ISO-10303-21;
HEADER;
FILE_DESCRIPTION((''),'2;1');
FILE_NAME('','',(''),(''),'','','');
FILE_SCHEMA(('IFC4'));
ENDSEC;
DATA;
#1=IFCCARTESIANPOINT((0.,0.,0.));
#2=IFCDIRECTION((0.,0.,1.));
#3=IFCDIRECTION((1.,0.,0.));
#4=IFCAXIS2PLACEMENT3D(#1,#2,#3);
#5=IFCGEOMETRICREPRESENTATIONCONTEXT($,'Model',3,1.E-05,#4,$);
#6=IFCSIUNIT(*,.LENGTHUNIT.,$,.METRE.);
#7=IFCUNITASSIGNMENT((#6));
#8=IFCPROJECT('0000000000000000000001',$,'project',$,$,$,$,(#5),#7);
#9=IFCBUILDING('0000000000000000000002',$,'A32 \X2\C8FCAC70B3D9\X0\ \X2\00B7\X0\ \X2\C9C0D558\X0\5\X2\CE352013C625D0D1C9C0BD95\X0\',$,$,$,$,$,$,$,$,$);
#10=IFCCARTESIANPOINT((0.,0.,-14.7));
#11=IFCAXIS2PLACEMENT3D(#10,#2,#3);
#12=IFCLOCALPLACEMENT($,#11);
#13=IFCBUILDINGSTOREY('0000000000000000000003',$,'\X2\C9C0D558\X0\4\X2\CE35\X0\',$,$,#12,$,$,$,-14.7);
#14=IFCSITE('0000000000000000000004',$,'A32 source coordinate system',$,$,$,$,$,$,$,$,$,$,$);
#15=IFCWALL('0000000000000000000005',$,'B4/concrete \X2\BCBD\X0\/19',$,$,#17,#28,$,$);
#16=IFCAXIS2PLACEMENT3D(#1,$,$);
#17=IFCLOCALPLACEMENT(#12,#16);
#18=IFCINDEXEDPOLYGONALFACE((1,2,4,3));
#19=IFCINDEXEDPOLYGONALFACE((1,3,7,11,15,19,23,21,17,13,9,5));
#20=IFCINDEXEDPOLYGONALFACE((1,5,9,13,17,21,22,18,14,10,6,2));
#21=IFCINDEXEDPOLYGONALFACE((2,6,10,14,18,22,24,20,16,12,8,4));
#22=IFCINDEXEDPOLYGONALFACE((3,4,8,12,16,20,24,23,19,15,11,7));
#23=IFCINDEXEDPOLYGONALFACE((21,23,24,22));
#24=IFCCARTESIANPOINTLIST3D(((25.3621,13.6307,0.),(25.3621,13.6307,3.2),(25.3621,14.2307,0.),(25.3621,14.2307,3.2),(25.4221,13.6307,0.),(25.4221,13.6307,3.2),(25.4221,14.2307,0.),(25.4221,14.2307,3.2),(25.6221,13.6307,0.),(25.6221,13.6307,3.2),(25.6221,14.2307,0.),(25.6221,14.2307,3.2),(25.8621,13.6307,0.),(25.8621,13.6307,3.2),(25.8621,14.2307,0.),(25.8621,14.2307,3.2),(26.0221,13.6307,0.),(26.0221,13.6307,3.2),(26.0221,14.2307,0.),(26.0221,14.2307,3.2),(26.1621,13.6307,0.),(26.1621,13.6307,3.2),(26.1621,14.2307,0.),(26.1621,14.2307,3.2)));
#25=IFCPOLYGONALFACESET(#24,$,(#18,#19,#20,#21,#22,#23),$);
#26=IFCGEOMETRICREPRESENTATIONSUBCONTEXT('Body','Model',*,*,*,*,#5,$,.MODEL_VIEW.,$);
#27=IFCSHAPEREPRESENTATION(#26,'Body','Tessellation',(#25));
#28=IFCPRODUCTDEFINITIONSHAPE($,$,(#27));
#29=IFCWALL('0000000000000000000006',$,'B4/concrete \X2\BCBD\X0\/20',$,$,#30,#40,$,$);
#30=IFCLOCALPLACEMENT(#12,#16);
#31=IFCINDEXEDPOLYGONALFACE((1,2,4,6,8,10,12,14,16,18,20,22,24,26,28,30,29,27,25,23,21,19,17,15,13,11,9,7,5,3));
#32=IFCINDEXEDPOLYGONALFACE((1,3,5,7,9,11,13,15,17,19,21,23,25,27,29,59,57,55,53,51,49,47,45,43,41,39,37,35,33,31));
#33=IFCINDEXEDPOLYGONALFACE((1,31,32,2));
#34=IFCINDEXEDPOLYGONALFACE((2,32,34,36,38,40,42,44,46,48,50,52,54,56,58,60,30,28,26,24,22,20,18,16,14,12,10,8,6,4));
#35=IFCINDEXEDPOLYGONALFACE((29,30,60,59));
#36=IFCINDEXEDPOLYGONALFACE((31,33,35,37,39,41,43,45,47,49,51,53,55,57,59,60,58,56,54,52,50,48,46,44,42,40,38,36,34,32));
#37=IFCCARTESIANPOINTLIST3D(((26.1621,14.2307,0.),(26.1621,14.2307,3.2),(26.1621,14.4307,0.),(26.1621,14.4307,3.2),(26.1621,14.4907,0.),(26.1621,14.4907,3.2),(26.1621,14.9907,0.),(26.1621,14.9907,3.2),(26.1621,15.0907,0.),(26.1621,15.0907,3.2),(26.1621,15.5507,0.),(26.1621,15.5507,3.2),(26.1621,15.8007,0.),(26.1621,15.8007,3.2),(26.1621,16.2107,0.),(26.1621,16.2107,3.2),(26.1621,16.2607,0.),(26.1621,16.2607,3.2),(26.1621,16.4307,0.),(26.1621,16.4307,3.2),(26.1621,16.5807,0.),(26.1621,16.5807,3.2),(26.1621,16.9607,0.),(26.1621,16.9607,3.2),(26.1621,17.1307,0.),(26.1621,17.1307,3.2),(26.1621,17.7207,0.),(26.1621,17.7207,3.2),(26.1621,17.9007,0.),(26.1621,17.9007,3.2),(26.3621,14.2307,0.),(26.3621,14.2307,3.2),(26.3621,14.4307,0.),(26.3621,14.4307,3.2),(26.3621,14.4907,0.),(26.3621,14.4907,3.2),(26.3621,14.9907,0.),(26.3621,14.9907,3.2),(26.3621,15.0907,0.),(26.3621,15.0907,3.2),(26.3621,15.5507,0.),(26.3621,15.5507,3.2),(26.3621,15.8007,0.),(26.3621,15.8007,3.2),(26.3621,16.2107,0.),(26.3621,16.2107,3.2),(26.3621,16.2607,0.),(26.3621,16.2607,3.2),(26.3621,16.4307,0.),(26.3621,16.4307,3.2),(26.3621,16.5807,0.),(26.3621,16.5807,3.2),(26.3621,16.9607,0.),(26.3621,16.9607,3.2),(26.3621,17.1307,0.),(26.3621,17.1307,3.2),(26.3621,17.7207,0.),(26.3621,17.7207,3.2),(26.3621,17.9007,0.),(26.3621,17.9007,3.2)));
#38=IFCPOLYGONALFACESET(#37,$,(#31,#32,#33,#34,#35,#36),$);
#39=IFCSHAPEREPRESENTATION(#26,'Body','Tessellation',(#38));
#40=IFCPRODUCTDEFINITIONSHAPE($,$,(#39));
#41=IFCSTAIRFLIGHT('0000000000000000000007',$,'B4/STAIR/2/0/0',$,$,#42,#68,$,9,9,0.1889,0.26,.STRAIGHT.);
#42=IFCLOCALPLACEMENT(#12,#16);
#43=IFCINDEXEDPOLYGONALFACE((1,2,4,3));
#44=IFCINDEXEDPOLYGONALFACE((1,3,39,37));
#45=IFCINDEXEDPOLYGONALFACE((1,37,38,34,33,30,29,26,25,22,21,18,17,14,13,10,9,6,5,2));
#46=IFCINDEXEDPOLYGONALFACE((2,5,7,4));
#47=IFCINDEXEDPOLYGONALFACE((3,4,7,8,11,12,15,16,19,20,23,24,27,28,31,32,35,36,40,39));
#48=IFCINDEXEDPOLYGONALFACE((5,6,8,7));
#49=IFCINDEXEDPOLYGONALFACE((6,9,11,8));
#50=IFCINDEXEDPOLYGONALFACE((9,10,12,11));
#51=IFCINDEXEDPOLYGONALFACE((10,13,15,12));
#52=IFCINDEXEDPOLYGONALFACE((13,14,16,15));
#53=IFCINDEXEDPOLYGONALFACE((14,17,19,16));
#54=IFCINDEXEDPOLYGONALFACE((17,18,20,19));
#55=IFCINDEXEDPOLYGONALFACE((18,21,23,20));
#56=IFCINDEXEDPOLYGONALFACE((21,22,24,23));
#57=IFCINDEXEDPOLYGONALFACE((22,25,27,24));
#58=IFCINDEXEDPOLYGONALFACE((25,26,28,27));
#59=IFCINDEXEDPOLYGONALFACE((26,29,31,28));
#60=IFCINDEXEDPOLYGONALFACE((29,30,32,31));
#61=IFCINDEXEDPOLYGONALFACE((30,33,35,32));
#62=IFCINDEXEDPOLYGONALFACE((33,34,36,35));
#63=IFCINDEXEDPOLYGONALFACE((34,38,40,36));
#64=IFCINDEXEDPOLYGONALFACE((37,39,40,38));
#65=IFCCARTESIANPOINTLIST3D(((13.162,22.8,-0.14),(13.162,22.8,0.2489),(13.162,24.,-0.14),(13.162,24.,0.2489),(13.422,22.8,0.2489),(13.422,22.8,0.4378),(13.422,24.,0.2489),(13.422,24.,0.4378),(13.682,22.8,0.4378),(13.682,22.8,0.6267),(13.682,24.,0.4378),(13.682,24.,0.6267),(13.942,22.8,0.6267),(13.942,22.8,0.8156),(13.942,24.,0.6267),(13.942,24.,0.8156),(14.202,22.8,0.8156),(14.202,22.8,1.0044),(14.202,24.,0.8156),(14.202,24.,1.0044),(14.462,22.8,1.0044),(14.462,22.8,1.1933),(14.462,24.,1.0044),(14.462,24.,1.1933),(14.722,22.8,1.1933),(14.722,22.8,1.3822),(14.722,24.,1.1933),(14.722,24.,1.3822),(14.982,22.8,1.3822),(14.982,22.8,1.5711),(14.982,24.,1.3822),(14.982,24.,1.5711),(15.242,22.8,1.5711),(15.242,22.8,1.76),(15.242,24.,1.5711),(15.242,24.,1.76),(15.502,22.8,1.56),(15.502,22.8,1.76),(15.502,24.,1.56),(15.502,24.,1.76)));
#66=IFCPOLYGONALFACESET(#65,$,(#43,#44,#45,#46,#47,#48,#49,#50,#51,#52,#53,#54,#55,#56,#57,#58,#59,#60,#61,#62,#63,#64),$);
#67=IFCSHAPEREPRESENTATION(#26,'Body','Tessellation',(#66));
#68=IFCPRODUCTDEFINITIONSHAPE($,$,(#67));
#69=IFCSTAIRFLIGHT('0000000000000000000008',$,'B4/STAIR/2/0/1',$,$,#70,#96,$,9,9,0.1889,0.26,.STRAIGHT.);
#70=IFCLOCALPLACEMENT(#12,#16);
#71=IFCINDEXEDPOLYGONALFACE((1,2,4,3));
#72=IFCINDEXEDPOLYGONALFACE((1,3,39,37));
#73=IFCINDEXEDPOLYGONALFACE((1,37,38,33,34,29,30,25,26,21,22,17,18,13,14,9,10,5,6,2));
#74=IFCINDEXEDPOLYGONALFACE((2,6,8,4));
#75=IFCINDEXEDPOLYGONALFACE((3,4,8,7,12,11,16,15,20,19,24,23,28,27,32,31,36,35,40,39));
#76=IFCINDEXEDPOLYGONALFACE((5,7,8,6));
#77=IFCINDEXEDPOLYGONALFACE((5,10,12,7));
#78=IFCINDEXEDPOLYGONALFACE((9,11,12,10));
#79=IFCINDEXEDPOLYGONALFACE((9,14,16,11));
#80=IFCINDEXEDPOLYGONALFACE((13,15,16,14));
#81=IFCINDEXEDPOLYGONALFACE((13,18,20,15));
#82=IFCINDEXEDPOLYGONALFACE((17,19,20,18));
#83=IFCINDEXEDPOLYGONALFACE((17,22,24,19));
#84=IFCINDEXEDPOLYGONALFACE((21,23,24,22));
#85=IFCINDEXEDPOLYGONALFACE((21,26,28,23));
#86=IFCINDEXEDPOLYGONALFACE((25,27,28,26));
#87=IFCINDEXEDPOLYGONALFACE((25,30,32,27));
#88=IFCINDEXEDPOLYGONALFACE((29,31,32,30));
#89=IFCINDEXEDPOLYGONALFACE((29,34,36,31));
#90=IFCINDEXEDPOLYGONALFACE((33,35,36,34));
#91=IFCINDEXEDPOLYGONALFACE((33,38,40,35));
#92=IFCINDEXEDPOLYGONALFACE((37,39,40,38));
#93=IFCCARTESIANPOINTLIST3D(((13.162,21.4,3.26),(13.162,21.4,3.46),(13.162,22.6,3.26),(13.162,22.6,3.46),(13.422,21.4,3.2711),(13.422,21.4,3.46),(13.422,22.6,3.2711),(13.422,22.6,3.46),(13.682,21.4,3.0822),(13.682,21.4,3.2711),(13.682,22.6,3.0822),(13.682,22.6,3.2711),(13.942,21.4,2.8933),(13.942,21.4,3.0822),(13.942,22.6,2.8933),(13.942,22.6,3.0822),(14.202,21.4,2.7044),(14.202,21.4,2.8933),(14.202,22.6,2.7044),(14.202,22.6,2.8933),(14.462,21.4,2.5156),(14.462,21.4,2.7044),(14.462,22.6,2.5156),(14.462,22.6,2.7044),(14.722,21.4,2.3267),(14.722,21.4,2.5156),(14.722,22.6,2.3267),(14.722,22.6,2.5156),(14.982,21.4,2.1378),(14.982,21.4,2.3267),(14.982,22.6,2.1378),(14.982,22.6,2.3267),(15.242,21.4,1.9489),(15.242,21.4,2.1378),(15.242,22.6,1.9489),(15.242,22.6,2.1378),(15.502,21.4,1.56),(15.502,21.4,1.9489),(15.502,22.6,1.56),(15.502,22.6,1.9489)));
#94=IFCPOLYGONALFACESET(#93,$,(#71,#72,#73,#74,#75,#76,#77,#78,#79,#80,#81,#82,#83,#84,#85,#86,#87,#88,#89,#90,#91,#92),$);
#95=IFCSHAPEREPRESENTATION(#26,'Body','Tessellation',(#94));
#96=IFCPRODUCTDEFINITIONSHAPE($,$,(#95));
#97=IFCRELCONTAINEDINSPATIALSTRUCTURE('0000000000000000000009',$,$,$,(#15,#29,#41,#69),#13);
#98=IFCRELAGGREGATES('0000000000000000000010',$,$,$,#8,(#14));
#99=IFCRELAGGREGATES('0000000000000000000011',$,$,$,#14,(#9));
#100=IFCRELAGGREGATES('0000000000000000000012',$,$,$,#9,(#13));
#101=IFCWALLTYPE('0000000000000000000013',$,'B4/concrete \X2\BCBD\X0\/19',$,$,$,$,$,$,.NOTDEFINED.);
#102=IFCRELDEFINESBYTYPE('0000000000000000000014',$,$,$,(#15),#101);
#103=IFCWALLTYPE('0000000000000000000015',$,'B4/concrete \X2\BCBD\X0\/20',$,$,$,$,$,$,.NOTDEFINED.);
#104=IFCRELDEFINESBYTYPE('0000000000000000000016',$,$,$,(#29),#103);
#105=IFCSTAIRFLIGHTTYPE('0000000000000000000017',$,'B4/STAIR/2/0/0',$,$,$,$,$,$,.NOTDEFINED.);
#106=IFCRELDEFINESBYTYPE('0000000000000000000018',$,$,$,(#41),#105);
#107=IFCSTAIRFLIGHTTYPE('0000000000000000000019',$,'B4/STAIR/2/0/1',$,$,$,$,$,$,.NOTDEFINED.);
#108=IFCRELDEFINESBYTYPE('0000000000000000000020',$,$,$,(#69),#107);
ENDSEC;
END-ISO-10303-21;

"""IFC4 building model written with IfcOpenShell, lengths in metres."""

from ifc_helpers import new_model, si_unit, frame, origin, origin_with_axes, place, context, subcontext, project, spatial, polyline, outline, extrude, source, transform, mapped, type_object, type_shapes, element, save


model = new_model("IFC4")

# Units and contexts
model_context = context("Model", 3, precision=1e-05, world=origin_with_axes())
body_context = subcontext(model_context, "Body", "Model", "MODEL_VIEW")
ifc_project = project(units=[si_unit("LENGTHUNIT", "METRE")], contexts=[model_context])

# Site, building, storey
site = spatial("IfcSite", under=ifc_project, Name="A32 source coordinate system")
building = spatial("IfcBuilding", under=site, Name="A32 주거동 · 지하5층–옥탑지붕")
storey_placement = place(None, frame((0.0, 0.0, -14.7), z_axis=(0.0, 0.0, 1.0), x_axis=(1.0, 0.0, 0.0)))
storey = spatial("IfcBuildingStorey", under=building, at=storey_placement, Name="지하4층", Elevation=-14.7)

# Walls
wall_type_1 = type_object("IfcWallType", Name="B4/concrete 벽/19", PredefinedType="NOTDEFINED")
shared_shape_1 = source(origin(), body_context, "Body", "SweptSolid", [
    extrude(outline(polyline([(25.8621, 14.2307), (26.0221, 14.2307), (26.1621, 14.2307), (26.1621, 13.6307), (26.0221, 13.6307), (25.8621, 13.6307), (25.6221, 13.6307), (25.4221, 13.6307), (25.3621, 13.6307), (25.3621, 14.2307), (25.4221, 14.2307), (25.6221, 14.2307), (25.8621, 14.2307)])), origin(), (0.0, 0.0, 1.0), 3.2),
])
type_shapes(wall_type_1, [shared_shape_1])
wall_1_placement = place(storey_placement, origin_with_axes())
element("IfcWall", 1, at=wall_1_placement, inside=storey, type_object=wall_type_1, Name="B4/concrete 벽/19", context=body_context, shape_type="MappedRepresentation", body=[
    mapped(shared_shape_1, transform((0.0, 0.0, 0.0), scale=1.0)),
])
wall_type_2 = type_object("IfcWallType", Name="B4/concrete 벽/20", PredefinedType="NOTDEFINED")
shared_shape_2 = source(origin(), body_context, "Body", "SweptSolid", [
    extrude(outline(polyline([(26.1621, 14.9907), (26.1621, 15.0907), (26.1621, 15.5507), (26.1621, 15.8007), (26.1621, 16.2107), (26.1621, 16.2607), (26.1621, 16.4307), (26.1621, 16.5807), (26.1621, 16.9607), (26.1621, 17.1307), (26.1621, 17.7207), (26.1621, 17.9007), (26.3621, 17.9007), (26.3621, 17.7207), (26.3621, 17.1307), (26.3621, 16.9607), (26.3621, 16.5807), (26.3621, 16.4307), (26.3621, 16.2607), (26.3621, 16.2107), (26.3621, 15.8007), (26.3621, 15.5507), (26.3621, 15.0907), (26.3621, 14.9907), (26.3621, 14.4907), (26.3621, 14.4307), (26.3621, 14.2307), (26.1621, 14.2307), (26.1621, 14.4307), (26.1621, 14.4907), (26.1621, 14.9907)])), origin(), (0.0, 0.0, 1.0), 3.2),
])
type_shapes(wall_type_2, [shared_shape_2])
wall_2_placement = place(storey_placement, origin_with_axes())
element("IfcWall", 2, at=wall_2_placement, inside=storey, type_object=wall_type_2, Name="B4/concrete 벽/20", context=body_context, shape_type="MappedRepresentation", body=[
    mapped(shared_shape_2, transform((0.0, 0.0, 0.0), scale=1.0)),
])

# Stair flights
stair_flight_type_1 = type_object("IfcStairFlightType", Name="B4/STAIR/2/0/0", PredefinedType="NOTDEFINED")
shared_shape_3 = source(origin(), body_context, "Body", "SweptSolid", [
    extrude(outline(polyline([(0.0, -0.14), (2.34, 1.56), (2.34, 1.76), (2.08, 1.76), (2.08, 1.5711), (1.82, 1.5711), (1.82, 1.3822), (1.56, 1.3822), (1.56, 1.1933), (1.3, 1.1933), (1.3, 1.0044), (1.04, 1.0044), (1.04, 0.8156), (0.78, 0.8156), (0.78, 0.6267), (0.52, 0.6267), (0.52, 0.4378), (0.26, 0.4378), (0.26, 0.2489), (0.0, 0.2489), (0.0, -0.14)])), frame((13.162, 24.0, 0.0), z_axis=(0.0, -1.0, 0.0), x_axis=(1.0, 0.0, 0.0)), (0.0, 0.0, 1.0), 1.2),
])
type_shapes(stair_flight_type_1, [shared_shape_3])
stair_flight_1_placement = place(storey_placement, origin_with_axes())
element("IfcStairFlight", 3, at=stair_flight_1_placement, inside=storey, type_object=stair_flight_type_1, Name="B4/STAIR/2/0/0", NumberOfRisers=9, NumberOfTreads=9, PredefinedType="STRAIGHT", RiserHeight=0.1889, TreadLength=0.26, context=body_context, shape_type="MappedRepresentation", body=[
    mapped(shared_shape_3, transform((0.0, 0.0, 0.0), scale=1.0)),
])
stair_flight_type_2 = type_object("IfcStairFlightType", Name="B4/STAIR/2/0/1", PredefinedType="NOTDEFINED")
shared_shape_4 = source(origin(), body_context, "Body", "SweptSolid", [
    extrude(outline(polyline([(0.0, 1.56), (2.34, 3.26), (2.34, 3.46), (2.08, 3.46), (2.08, 3.2711), (1.82, 3.2711), (1.82, 3.0822), (1.56, 3.0822), (1.56, 2.8933), (1.3, 2.8933), (1.3, 2.7044), (1.04, 2.7044), (1.04, 2.5156), (0.78, 2.5156), (0.78, 2.3267), (0.52, 2.3267), (0.52, 2.1378), (0.26, 2.1378), (0.26, 1.9489), (0.0, 1.9489), (0.0, 1.56)])), frame((15.502, 21.4, 0.0), z_axis=(0.0, 1.0, 0.0), x_axis=(-1.0, 0.0, 0.0)), (0.0, 0.0, 1.0), 1.2),
])
type_shapes(stair_flight_type_2, [shared_shape_4])
stair_flight_2_placement = place(storey_placement, origin_with_axes())
element("IfcStairFlight", 4, at=stair_flight_2_placement, inside=storey, type_object=stair_flight_type_2, Name="B4/STAIR/2/0/1", NumberOfRisers=9, NumberOfTreads=9, PredefinedType="STRAIGHT", RiserHeight=0.1889, TreadLength=0.26, context=body_context, shape_type="MappedRepresentation", body=[
    mapped(shared_shape_4, transform((0.0, 0.0, 0.0), scale=1.0)),
])

save(model, "model.ifc")
